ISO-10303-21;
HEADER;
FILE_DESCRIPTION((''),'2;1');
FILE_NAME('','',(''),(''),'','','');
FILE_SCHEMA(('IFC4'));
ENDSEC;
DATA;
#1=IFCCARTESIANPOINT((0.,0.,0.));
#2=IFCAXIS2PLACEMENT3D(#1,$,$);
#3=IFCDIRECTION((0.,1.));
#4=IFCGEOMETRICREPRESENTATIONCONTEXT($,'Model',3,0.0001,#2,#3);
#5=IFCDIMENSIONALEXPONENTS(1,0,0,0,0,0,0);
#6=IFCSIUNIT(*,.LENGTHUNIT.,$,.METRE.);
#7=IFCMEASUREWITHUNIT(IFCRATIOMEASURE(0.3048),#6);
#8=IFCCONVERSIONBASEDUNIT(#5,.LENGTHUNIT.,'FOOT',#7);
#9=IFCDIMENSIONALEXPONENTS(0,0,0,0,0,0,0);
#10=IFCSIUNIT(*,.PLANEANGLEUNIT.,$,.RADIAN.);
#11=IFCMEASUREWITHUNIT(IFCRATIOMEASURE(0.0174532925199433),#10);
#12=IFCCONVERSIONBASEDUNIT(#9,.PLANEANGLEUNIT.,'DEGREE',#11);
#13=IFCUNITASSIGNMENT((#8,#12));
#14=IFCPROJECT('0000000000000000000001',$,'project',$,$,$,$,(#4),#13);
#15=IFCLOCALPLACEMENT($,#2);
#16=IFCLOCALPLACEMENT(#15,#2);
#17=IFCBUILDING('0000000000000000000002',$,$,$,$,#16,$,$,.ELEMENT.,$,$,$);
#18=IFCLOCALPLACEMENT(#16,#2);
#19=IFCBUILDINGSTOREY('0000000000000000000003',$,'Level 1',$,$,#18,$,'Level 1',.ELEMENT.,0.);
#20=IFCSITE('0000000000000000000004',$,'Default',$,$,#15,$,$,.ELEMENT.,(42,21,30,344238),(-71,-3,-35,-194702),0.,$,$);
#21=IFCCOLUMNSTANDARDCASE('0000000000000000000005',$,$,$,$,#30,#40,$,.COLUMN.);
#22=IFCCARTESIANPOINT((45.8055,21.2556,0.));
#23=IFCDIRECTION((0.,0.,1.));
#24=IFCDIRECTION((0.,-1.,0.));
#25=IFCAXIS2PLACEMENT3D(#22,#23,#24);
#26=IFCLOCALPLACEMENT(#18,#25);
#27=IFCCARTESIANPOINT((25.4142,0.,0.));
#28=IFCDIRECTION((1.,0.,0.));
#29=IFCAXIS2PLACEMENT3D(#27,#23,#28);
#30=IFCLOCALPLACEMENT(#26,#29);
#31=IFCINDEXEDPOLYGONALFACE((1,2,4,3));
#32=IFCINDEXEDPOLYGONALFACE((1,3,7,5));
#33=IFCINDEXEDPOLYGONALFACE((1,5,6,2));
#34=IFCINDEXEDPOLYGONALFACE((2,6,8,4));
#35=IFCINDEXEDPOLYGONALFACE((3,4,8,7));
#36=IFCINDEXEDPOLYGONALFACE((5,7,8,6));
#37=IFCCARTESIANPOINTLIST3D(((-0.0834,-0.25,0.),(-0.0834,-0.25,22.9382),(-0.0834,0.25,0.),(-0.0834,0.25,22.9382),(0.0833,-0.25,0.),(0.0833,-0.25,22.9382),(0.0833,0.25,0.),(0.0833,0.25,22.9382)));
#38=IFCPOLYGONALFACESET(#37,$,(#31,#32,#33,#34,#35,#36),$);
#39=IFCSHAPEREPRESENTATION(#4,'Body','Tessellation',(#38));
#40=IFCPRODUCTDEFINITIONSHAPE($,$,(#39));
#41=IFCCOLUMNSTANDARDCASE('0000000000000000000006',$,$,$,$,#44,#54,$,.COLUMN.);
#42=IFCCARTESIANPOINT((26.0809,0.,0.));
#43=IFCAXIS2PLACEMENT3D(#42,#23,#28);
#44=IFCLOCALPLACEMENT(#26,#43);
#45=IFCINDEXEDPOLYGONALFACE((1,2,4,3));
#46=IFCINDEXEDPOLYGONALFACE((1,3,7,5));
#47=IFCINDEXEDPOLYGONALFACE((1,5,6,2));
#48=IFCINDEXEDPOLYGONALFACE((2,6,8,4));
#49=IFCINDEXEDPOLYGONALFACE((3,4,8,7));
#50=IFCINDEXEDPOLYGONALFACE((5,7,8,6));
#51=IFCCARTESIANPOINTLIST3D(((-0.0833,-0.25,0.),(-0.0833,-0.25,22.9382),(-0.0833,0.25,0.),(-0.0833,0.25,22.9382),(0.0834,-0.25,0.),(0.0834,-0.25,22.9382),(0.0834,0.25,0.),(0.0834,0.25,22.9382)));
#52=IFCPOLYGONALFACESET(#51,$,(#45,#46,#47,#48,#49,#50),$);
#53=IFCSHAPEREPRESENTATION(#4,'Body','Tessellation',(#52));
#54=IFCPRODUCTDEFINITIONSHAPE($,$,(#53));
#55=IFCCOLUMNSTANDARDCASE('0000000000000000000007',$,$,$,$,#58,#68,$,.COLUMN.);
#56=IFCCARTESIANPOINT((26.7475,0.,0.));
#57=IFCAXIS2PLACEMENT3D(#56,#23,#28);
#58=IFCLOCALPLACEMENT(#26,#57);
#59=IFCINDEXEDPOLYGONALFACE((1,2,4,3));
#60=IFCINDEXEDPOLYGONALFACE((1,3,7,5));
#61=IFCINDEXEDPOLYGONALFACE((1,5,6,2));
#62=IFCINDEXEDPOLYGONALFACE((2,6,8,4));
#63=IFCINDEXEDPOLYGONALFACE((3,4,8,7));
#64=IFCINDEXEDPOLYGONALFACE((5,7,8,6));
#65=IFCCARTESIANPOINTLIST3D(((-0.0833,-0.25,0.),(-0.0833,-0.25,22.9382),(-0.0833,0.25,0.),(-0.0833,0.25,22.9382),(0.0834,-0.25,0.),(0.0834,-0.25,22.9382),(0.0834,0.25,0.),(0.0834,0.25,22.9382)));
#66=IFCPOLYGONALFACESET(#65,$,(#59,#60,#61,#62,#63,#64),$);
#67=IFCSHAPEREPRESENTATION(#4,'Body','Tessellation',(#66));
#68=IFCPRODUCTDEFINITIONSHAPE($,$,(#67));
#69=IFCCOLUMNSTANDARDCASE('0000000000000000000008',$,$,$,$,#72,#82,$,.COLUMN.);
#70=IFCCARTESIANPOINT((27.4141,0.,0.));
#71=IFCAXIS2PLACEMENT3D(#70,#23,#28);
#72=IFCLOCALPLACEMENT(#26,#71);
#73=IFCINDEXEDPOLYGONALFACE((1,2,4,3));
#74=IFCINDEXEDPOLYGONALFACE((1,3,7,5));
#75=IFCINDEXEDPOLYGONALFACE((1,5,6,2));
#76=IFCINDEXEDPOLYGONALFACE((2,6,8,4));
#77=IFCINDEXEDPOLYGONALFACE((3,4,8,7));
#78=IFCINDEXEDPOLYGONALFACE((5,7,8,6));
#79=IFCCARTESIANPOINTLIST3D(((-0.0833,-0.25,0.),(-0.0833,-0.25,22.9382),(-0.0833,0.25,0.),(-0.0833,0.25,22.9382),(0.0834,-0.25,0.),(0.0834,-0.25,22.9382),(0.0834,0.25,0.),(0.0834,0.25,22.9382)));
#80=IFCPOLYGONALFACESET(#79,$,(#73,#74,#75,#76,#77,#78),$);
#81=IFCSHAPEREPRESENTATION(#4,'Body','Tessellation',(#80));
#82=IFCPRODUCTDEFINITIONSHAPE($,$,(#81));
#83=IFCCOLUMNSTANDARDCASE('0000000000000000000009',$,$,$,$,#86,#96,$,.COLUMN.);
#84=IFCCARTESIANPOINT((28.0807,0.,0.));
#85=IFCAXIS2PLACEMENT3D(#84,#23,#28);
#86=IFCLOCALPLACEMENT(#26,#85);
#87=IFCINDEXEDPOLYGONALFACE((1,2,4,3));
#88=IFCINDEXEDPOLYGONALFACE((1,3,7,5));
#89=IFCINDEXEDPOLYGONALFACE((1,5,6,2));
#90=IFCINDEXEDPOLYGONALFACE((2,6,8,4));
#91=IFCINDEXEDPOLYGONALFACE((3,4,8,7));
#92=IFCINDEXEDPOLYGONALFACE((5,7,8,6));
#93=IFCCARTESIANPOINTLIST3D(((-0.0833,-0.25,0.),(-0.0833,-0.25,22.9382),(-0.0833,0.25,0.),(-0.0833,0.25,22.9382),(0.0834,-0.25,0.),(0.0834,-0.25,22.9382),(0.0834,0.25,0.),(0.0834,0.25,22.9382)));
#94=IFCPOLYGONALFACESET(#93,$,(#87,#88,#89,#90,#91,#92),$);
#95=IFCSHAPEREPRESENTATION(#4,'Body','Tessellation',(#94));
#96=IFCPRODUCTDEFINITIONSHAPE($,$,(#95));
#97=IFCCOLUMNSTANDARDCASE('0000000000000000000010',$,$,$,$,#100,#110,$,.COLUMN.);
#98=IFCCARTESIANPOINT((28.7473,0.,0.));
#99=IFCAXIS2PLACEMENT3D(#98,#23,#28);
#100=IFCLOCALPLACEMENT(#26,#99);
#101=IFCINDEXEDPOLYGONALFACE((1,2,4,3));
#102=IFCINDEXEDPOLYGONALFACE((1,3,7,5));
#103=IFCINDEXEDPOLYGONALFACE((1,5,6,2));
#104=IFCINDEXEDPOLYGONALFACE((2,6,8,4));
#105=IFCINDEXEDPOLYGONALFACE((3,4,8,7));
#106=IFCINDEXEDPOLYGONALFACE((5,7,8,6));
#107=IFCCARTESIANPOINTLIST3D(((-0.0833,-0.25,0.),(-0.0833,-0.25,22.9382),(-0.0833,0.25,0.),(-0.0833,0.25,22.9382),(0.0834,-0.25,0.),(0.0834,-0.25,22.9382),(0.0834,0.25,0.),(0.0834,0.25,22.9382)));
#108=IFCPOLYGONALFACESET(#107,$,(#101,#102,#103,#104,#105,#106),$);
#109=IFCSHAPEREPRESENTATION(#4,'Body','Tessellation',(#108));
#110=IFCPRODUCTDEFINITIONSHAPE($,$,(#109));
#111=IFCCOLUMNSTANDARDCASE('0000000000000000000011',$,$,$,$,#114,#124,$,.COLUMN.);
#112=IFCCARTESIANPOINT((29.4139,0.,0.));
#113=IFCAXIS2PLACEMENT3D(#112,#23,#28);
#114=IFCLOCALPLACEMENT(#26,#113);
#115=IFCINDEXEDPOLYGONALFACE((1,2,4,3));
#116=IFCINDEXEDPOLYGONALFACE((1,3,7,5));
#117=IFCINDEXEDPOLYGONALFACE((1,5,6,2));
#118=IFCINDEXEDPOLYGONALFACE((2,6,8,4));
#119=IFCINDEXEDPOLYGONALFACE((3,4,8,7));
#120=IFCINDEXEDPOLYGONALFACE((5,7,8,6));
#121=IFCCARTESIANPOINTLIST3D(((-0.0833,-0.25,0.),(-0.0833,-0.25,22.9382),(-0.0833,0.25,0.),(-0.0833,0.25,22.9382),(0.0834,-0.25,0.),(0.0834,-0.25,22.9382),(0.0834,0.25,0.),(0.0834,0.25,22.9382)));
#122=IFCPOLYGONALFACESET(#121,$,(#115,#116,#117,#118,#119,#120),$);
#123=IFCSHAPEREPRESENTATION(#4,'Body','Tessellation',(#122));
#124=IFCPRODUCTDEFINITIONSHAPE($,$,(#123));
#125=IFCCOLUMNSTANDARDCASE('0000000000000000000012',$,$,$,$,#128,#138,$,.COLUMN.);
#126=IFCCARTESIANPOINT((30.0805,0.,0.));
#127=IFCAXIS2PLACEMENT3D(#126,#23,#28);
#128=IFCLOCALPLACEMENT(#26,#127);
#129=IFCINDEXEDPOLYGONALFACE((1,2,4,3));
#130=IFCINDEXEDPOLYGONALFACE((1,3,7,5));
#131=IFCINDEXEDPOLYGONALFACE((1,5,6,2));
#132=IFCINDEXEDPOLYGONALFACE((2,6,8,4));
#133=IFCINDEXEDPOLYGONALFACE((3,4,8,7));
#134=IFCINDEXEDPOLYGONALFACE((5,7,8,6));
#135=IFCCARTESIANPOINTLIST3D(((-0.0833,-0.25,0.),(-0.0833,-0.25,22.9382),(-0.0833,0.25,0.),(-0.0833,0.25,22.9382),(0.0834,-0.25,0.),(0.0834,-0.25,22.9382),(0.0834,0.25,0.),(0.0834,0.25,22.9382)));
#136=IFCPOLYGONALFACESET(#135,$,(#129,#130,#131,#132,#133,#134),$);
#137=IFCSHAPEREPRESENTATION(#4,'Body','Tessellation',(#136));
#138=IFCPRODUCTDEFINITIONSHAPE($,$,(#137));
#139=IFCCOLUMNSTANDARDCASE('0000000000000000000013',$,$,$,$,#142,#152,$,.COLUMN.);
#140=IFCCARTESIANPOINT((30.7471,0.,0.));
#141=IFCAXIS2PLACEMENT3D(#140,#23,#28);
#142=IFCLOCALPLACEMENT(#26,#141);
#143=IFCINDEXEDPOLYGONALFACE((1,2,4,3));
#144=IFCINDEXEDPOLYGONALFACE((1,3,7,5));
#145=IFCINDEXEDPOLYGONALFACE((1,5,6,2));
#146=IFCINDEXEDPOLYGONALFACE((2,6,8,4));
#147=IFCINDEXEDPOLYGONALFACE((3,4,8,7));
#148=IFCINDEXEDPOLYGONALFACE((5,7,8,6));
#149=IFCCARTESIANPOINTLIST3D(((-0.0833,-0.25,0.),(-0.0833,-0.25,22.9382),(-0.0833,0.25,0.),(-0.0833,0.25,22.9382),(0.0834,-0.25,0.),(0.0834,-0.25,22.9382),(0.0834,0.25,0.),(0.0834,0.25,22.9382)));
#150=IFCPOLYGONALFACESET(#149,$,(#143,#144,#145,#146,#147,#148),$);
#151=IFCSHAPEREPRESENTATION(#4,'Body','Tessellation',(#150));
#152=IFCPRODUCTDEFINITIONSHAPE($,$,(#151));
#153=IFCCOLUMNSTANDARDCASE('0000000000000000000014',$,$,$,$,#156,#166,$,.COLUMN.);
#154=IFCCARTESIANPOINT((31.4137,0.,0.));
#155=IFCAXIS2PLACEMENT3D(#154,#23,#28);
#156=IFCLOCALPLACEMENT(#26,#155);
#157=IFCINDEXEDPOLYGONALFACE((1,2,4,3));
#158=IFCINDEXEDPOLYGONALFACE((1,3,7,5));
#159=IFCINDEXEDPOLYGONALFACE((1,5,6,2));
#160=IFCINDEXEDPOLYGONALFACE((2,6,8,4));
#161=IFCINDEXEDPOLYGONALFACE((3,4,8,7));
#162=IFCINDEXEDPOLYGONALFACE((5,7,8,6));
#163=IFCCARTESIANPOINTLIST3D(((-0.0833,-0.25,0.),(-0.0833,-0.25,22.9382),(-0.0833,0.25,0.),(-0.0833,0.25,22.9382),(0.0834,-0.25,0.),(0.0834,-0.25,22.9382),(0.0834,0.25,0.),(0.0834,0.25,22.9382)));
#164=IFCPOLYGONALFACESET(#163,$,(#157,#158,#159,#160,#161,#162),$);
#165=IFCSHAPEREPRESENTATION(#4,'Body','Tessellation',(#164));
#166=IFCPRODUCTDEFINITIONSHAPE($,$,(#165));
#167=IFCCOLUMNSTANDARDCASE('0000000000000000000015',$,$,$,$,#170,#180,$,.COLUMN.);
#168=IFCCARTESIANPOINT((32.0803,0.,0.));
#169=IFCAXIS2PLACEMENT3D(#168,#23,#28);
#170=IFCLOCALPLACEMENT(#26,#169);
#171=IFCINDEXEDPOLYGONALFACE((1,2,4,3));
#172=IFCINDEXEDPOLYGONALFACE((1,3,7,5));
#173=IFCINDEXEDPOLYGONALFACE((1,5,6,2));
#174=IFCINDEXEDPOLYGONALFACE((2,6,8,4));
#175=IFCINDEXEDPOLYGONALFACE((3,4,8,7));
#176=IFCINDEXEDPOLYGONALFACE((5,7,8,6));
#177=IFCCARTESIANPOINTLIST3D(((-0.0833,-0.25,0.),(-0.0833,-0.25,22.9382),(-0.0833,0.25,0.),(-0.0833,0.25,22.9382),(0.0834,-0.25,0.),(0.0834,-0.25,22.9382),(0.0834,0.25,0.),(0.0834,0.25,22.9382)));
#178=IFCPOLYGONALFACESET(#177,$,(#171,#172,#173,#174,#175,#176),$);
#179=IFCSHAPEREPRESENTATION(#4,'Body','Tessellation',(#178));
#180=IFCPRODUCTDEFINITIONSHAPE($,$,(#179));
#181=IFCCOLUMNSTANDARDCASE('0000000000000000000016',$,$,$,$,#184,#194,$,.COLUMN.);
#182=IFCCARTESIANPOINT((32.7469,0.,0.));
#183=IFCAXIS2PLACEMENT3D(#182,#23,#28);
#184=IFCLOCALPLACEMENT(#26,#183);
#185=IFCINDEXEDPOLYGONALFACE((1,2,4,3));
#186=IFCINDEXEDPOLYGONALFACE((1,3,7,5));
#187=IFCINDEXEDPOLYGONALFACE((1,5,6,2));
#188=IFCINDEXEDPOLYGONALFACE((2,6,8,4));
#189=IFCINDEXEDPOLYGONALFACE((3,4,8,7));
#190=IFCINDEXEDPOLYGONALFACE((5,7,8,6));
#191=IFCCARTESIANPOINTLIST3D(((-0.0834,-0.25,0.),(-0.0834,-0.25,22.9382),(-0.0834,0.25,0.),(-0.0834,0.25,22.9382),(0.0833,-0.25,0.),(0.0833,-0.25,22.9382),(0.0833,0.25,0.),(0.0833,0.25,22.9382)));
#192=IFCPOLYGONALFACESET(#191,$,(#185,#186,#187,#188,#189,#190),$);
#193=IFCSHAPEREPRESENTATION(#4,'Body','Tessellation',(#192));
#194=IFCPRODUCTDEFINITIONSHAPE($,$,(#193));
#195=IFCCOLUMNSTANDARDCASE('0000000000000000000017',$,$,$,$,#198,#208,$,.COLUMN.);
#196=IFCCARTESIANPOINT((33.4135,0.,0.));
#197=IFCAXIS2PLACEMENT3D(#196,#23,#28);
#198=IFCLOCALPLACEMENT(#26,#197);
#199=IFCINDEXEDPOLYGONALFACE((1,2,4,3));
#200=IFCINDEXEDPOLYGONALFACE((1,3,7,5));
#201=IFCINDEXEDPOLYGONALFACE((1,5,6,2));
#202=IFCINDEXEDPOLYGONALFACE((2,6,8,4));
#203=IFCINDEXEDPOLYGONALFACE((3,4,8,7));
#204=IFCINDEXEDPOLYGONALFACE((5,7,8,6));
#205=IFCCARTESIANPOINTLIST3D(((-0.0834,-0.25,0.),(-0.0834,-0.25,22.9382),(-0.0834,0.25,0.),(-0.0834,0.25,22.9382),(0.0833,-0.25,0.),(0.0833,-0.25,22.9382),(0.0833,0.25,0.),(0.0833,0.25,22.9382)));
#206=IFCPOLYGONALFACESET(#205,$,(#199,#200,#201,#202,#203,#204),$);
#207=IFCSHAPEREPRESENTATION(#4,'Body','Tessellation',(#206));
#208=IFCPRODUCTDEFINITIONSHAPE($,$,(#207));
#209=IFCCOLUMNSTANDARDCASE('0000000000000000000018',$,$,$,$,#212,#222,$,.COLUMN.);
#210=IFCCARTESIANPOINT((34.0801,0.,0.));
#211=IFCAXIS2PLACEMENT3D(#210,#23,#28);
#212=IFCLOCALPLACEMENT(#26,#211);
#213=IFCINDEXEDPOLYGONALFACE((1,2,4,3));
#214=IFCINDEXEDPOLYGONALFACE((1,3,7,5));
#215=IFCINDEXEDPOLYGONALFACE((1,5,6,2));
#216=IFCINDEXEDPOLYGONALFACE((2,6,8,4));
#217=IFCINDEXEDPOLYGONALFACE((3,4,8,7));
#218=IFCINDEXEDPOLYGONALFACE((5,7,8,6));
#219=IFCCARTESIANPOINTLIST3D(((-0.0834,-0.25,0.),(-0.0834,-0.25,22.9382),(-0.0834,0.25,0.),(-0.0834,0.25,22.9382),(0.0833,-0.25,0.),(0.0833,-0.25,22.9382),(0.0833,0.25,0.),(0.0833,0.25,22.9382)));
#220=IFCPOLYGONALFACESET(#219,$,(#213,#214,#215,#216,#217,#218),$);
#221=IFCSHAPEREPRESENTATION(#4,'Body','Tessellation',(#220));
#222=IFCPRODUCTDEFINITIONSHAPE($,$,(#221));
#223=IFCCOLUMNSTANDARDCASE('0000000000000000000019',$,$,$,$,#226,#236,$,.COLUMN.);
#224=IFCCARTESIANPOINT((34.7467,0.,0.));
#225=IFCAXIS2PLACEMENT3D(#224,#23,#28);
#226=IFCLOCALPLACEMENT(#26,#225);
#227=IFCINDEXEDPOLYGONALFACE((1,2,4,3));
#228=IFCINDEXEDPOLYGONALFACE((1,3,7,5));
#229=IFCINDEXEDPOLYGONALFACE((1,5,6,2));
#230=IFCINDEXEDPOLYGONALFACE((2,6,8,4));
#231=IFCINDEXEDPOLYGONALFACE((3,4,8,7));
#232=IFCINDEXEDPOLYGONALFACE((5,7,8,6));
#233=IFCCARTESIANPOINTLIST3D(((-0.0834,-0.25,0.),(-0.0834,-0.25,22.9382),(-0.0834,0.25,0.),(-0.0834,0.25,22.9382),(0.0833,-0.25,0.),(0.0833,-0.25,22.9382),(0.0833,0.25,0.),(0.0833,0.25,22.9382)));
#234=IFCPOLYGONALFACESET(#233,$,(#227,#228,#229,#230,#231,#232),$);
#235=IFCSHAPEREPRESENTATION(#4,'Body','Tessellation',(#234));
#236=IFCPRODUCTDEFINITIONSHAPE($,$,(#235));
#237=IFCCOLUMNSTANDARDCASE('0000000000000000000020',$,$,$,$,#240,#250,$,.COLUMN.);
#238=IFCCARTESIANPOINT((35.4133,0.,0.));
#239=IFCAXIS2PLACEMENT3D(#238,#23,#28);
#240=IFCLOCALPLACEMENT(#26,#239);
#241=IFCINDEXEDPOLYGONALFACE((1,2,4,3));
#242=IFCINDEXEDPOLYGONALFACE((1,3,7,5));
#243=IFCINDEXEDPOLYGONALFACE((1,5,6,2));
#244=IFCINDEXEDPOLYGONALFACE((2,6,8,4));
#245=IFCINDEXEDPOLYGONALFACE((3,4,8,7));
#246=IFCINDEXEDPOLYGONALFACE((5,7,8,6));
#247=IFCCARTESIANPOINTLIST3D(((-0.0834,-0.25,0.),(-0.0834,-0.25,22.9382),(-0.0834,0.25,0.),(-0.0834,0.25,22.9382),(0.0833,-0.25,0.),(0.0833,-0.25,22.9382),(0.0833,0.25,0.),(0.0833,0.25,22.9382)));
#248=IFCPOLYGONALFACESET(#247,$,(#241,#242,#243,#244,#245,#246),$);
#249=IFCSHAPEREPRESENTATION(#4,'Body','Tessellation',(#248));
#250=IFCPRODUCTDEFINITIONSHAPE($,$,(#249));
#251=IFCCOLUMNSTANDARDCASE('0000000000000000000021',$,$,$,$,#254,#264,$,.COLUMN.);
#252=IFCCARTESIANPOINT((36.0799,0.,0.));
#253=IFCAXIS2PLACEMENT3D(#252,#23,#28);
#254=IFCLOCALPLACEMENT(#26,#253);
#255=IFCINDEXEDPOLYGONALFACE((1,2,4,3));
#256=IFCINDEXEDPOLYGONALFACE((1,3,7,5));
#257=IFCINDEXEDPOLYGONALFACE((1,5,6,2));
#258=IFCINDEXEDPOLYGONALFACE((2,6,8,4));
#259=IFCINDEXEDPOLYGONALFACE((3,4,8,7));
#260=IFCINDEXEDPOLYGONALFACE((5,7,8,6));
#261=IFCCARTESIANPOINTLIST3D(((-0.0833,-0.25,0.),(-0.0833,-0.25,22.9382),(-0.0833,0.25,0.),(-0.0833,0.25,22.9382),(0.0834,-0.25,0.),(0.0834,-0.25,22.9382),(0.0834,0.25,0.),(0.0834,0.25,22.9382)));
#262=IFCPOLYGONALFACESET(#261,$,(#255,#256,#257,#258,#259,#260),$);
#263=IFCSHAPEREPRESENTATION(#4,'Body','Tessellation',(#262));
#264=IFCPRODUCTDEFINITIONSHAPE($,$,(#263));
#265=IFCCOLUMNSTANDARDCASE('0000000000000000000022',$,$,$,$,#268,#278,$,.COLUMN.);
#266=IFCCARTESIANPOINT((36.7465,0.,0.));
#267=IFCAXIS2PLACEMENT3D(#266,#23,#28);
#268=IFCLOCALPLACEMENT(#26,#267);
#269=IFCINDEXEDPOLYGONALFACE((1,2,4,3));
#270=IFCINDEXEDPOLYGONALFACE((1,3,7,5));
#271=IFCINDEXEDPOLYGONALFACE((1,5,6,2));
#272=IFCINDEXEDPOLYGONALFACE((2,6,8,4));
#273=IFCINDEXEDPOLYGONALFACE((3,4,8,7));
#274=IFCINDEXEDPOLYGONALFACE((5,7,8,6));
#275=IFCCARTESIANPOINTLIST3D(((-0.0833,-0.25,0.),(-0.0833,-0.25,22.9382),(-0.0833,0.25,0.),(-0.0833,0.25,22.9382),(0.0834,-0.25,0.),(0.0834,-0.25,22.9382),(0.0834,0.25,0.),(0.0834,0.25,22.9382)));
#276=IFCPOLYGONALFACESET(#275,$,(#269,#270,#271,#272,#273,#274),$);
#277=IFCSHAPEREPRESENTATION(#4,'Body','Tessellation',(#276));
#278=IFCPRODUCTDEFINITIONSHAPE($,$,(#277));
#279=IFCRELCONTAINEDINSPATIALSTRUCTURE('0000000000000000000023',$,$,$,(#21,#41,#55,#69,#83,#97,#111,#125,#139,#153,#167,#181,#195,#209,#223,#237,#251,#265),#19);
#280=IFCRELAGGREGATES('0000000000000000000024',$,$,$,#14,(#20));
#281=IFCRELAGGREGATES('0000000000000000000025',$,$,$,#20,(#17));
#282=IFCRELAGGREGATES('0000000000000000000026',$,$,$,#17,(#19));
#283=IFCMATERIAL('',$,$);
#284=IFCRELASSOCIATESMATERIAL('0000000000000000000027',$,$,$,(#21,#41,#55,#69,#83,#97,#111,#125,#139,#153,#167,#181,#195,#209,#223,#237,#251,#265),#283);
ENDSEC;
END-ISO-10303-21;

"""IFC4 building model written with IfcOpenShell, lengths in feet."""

from ifc_helpers import new_model, entity, si_unit, converted_unit, direction, frame, origin, place, context, project, spatial, rectangle, extrude, material, element, save


model = new_model("IFC4")

# Units and contexts
model_context = context("Model", 3, precision=0.0001, world=origin(), true_north=direction((0.0, 1.0)))
ifc_project = project(units=[converted_unit("LENGTHUNIT", "FOOT", entity("IfcRatioMeasure", 0.3048), si_unit("LENGTHUNIT", "METRE"), dimensions=[1, 0, 0, 0, 0, 0, 0]), converted_unit("PLANEANGLEUNIT", "DEGREE", entity("IfcRatioMeasure", 0.0174532925199433), si_unit("PLANEANGLEUNIT", "RADIAN"), dimensions=[0, 0, 0, 0, 0, 0, 0])], contexts=[model_context])

# Site, building, storey
site_placement = place(None, origin())
site = spatial("IfcSite", under=ifc_project, at=site_placement, Name="Default", CompositionType="ELEMENT", RefLatitude=(42, 21, 30, 344238), RefLongitude=(-71, -3, -35, -194702), RefElevation=0.0)
building_placement = place(site_placement, origin())
building = spatial("IfcBuilding", under=site, at=building_placement, CompositionType="ELEMENT")
storey_placement = place(building_placement, origin())
storey = spatial("IfcBuildingStorey", under=building, at=storey_placement, Name="Level 1", LongName="Level 1", CompositionType="ELEMENT", Elevation=0.0)

# Columns
ifc_material = material(Name="")
placement = place(storey_placement, frame((45.8055, 21.2556, 0.0), z_axis=(0.0, 0.0, 1.0), x_axis=(0.0, -1.0, 0.0)))
for number, where, z_axis, x_axis in (
    (1, (25.4142, 0.0, 0.0), (0.0, 0.0, 1.0), (1.0, 0.0, 0.0)),
    (2, (26.0809, 0.0, 0.0), (0.0, 0.0, 1.0), (1.0, 0.0, 0.0)),
    (3, (26.7475, 0.0, 0.0), (0.0, 0.0, 1.0), (1.0, 0.0, 0.0)),
    (4, (27.4141, 0.0, 0.0), (0.0, 0.0, 1.0), (1.0, 0.0, 0.0)),
    (5, (28.0807, 0.0, 0.0), (0.0, 0.0, 1.0), (1.0, 0.0, 0.0)),
    (6, (28.7473, 0.0, 0.0), (0.0, 0.0, 1.0), (1.0, 0.0, 0.0)),
    (7, (29.4139, 0.0, 0.0), (0.0, 0.0, 1.0), (1.0, 0.0, 0.0)),
    (8, (30.0805, 0.0, 0.0), (0.0, 0.0, 1.0), (1.0, 0.0, 0.0)),
    (9, (30.7471, 0.0, 0.0), (0.0, 0.0, 1.0), (1.0, 0.0, 0.0)),
    (10, (31.4137, 0.0, 0.0), (0.0, 0.0, 1.0), (1.0, 0.0, 0.0)),
    (11, (32.0803, 0.0, 0.0), (0.0, 0.0, 1.0), (1.0, 0.0, 0.0)),
    (12, (32.7469, 0.0, 0.0), (0.0, 0.0, 1.0), (1.0, 0.0, 0.0)),
    (13, (33.4135, 0.0, 0.0), (0.0, 0.0, 1.0), (1.0, 0.0, 0.0)),
    (14, (34.0801, 0.0, 0.0), (0.0, 0.0, 1.0), (1.0, 0.0, 0.0)),
    (15, (34.7467, 0.0, 0.0), (0.0, 0.0, 1.0), (1.0, 0.0, 0.0)),
    (16, (35.4133, 0.0, 0.0), (0.0, 0.0, 1.0), (1.0, 0.0, 0.0)),
    (17, (36.0799, 0.0, 0.0), (0.0, 0.0, 1.0), (1.0, 0.0, 0.0)),
    (18, (36.7465, 0.0, 0.0), (0.0, 0.0, 1.0), (1.0, 0.0, 0.0)),
):
    element("IfcColumnStandardCase", number, at=place(placement, frame(where, z_axis=z_axis, x_axis=x_axis)), inside=storey, material=ifc_material, PredefinedType="COLUMN", context=model_context, shape_type="SweptSolid", body=[
        extrude(rectangle(XDim=0.1667, YDim=0.5), origin(), (0.0, 0.0, 1.0), 22.9382),
    ])

save(model, "model.ifc")
